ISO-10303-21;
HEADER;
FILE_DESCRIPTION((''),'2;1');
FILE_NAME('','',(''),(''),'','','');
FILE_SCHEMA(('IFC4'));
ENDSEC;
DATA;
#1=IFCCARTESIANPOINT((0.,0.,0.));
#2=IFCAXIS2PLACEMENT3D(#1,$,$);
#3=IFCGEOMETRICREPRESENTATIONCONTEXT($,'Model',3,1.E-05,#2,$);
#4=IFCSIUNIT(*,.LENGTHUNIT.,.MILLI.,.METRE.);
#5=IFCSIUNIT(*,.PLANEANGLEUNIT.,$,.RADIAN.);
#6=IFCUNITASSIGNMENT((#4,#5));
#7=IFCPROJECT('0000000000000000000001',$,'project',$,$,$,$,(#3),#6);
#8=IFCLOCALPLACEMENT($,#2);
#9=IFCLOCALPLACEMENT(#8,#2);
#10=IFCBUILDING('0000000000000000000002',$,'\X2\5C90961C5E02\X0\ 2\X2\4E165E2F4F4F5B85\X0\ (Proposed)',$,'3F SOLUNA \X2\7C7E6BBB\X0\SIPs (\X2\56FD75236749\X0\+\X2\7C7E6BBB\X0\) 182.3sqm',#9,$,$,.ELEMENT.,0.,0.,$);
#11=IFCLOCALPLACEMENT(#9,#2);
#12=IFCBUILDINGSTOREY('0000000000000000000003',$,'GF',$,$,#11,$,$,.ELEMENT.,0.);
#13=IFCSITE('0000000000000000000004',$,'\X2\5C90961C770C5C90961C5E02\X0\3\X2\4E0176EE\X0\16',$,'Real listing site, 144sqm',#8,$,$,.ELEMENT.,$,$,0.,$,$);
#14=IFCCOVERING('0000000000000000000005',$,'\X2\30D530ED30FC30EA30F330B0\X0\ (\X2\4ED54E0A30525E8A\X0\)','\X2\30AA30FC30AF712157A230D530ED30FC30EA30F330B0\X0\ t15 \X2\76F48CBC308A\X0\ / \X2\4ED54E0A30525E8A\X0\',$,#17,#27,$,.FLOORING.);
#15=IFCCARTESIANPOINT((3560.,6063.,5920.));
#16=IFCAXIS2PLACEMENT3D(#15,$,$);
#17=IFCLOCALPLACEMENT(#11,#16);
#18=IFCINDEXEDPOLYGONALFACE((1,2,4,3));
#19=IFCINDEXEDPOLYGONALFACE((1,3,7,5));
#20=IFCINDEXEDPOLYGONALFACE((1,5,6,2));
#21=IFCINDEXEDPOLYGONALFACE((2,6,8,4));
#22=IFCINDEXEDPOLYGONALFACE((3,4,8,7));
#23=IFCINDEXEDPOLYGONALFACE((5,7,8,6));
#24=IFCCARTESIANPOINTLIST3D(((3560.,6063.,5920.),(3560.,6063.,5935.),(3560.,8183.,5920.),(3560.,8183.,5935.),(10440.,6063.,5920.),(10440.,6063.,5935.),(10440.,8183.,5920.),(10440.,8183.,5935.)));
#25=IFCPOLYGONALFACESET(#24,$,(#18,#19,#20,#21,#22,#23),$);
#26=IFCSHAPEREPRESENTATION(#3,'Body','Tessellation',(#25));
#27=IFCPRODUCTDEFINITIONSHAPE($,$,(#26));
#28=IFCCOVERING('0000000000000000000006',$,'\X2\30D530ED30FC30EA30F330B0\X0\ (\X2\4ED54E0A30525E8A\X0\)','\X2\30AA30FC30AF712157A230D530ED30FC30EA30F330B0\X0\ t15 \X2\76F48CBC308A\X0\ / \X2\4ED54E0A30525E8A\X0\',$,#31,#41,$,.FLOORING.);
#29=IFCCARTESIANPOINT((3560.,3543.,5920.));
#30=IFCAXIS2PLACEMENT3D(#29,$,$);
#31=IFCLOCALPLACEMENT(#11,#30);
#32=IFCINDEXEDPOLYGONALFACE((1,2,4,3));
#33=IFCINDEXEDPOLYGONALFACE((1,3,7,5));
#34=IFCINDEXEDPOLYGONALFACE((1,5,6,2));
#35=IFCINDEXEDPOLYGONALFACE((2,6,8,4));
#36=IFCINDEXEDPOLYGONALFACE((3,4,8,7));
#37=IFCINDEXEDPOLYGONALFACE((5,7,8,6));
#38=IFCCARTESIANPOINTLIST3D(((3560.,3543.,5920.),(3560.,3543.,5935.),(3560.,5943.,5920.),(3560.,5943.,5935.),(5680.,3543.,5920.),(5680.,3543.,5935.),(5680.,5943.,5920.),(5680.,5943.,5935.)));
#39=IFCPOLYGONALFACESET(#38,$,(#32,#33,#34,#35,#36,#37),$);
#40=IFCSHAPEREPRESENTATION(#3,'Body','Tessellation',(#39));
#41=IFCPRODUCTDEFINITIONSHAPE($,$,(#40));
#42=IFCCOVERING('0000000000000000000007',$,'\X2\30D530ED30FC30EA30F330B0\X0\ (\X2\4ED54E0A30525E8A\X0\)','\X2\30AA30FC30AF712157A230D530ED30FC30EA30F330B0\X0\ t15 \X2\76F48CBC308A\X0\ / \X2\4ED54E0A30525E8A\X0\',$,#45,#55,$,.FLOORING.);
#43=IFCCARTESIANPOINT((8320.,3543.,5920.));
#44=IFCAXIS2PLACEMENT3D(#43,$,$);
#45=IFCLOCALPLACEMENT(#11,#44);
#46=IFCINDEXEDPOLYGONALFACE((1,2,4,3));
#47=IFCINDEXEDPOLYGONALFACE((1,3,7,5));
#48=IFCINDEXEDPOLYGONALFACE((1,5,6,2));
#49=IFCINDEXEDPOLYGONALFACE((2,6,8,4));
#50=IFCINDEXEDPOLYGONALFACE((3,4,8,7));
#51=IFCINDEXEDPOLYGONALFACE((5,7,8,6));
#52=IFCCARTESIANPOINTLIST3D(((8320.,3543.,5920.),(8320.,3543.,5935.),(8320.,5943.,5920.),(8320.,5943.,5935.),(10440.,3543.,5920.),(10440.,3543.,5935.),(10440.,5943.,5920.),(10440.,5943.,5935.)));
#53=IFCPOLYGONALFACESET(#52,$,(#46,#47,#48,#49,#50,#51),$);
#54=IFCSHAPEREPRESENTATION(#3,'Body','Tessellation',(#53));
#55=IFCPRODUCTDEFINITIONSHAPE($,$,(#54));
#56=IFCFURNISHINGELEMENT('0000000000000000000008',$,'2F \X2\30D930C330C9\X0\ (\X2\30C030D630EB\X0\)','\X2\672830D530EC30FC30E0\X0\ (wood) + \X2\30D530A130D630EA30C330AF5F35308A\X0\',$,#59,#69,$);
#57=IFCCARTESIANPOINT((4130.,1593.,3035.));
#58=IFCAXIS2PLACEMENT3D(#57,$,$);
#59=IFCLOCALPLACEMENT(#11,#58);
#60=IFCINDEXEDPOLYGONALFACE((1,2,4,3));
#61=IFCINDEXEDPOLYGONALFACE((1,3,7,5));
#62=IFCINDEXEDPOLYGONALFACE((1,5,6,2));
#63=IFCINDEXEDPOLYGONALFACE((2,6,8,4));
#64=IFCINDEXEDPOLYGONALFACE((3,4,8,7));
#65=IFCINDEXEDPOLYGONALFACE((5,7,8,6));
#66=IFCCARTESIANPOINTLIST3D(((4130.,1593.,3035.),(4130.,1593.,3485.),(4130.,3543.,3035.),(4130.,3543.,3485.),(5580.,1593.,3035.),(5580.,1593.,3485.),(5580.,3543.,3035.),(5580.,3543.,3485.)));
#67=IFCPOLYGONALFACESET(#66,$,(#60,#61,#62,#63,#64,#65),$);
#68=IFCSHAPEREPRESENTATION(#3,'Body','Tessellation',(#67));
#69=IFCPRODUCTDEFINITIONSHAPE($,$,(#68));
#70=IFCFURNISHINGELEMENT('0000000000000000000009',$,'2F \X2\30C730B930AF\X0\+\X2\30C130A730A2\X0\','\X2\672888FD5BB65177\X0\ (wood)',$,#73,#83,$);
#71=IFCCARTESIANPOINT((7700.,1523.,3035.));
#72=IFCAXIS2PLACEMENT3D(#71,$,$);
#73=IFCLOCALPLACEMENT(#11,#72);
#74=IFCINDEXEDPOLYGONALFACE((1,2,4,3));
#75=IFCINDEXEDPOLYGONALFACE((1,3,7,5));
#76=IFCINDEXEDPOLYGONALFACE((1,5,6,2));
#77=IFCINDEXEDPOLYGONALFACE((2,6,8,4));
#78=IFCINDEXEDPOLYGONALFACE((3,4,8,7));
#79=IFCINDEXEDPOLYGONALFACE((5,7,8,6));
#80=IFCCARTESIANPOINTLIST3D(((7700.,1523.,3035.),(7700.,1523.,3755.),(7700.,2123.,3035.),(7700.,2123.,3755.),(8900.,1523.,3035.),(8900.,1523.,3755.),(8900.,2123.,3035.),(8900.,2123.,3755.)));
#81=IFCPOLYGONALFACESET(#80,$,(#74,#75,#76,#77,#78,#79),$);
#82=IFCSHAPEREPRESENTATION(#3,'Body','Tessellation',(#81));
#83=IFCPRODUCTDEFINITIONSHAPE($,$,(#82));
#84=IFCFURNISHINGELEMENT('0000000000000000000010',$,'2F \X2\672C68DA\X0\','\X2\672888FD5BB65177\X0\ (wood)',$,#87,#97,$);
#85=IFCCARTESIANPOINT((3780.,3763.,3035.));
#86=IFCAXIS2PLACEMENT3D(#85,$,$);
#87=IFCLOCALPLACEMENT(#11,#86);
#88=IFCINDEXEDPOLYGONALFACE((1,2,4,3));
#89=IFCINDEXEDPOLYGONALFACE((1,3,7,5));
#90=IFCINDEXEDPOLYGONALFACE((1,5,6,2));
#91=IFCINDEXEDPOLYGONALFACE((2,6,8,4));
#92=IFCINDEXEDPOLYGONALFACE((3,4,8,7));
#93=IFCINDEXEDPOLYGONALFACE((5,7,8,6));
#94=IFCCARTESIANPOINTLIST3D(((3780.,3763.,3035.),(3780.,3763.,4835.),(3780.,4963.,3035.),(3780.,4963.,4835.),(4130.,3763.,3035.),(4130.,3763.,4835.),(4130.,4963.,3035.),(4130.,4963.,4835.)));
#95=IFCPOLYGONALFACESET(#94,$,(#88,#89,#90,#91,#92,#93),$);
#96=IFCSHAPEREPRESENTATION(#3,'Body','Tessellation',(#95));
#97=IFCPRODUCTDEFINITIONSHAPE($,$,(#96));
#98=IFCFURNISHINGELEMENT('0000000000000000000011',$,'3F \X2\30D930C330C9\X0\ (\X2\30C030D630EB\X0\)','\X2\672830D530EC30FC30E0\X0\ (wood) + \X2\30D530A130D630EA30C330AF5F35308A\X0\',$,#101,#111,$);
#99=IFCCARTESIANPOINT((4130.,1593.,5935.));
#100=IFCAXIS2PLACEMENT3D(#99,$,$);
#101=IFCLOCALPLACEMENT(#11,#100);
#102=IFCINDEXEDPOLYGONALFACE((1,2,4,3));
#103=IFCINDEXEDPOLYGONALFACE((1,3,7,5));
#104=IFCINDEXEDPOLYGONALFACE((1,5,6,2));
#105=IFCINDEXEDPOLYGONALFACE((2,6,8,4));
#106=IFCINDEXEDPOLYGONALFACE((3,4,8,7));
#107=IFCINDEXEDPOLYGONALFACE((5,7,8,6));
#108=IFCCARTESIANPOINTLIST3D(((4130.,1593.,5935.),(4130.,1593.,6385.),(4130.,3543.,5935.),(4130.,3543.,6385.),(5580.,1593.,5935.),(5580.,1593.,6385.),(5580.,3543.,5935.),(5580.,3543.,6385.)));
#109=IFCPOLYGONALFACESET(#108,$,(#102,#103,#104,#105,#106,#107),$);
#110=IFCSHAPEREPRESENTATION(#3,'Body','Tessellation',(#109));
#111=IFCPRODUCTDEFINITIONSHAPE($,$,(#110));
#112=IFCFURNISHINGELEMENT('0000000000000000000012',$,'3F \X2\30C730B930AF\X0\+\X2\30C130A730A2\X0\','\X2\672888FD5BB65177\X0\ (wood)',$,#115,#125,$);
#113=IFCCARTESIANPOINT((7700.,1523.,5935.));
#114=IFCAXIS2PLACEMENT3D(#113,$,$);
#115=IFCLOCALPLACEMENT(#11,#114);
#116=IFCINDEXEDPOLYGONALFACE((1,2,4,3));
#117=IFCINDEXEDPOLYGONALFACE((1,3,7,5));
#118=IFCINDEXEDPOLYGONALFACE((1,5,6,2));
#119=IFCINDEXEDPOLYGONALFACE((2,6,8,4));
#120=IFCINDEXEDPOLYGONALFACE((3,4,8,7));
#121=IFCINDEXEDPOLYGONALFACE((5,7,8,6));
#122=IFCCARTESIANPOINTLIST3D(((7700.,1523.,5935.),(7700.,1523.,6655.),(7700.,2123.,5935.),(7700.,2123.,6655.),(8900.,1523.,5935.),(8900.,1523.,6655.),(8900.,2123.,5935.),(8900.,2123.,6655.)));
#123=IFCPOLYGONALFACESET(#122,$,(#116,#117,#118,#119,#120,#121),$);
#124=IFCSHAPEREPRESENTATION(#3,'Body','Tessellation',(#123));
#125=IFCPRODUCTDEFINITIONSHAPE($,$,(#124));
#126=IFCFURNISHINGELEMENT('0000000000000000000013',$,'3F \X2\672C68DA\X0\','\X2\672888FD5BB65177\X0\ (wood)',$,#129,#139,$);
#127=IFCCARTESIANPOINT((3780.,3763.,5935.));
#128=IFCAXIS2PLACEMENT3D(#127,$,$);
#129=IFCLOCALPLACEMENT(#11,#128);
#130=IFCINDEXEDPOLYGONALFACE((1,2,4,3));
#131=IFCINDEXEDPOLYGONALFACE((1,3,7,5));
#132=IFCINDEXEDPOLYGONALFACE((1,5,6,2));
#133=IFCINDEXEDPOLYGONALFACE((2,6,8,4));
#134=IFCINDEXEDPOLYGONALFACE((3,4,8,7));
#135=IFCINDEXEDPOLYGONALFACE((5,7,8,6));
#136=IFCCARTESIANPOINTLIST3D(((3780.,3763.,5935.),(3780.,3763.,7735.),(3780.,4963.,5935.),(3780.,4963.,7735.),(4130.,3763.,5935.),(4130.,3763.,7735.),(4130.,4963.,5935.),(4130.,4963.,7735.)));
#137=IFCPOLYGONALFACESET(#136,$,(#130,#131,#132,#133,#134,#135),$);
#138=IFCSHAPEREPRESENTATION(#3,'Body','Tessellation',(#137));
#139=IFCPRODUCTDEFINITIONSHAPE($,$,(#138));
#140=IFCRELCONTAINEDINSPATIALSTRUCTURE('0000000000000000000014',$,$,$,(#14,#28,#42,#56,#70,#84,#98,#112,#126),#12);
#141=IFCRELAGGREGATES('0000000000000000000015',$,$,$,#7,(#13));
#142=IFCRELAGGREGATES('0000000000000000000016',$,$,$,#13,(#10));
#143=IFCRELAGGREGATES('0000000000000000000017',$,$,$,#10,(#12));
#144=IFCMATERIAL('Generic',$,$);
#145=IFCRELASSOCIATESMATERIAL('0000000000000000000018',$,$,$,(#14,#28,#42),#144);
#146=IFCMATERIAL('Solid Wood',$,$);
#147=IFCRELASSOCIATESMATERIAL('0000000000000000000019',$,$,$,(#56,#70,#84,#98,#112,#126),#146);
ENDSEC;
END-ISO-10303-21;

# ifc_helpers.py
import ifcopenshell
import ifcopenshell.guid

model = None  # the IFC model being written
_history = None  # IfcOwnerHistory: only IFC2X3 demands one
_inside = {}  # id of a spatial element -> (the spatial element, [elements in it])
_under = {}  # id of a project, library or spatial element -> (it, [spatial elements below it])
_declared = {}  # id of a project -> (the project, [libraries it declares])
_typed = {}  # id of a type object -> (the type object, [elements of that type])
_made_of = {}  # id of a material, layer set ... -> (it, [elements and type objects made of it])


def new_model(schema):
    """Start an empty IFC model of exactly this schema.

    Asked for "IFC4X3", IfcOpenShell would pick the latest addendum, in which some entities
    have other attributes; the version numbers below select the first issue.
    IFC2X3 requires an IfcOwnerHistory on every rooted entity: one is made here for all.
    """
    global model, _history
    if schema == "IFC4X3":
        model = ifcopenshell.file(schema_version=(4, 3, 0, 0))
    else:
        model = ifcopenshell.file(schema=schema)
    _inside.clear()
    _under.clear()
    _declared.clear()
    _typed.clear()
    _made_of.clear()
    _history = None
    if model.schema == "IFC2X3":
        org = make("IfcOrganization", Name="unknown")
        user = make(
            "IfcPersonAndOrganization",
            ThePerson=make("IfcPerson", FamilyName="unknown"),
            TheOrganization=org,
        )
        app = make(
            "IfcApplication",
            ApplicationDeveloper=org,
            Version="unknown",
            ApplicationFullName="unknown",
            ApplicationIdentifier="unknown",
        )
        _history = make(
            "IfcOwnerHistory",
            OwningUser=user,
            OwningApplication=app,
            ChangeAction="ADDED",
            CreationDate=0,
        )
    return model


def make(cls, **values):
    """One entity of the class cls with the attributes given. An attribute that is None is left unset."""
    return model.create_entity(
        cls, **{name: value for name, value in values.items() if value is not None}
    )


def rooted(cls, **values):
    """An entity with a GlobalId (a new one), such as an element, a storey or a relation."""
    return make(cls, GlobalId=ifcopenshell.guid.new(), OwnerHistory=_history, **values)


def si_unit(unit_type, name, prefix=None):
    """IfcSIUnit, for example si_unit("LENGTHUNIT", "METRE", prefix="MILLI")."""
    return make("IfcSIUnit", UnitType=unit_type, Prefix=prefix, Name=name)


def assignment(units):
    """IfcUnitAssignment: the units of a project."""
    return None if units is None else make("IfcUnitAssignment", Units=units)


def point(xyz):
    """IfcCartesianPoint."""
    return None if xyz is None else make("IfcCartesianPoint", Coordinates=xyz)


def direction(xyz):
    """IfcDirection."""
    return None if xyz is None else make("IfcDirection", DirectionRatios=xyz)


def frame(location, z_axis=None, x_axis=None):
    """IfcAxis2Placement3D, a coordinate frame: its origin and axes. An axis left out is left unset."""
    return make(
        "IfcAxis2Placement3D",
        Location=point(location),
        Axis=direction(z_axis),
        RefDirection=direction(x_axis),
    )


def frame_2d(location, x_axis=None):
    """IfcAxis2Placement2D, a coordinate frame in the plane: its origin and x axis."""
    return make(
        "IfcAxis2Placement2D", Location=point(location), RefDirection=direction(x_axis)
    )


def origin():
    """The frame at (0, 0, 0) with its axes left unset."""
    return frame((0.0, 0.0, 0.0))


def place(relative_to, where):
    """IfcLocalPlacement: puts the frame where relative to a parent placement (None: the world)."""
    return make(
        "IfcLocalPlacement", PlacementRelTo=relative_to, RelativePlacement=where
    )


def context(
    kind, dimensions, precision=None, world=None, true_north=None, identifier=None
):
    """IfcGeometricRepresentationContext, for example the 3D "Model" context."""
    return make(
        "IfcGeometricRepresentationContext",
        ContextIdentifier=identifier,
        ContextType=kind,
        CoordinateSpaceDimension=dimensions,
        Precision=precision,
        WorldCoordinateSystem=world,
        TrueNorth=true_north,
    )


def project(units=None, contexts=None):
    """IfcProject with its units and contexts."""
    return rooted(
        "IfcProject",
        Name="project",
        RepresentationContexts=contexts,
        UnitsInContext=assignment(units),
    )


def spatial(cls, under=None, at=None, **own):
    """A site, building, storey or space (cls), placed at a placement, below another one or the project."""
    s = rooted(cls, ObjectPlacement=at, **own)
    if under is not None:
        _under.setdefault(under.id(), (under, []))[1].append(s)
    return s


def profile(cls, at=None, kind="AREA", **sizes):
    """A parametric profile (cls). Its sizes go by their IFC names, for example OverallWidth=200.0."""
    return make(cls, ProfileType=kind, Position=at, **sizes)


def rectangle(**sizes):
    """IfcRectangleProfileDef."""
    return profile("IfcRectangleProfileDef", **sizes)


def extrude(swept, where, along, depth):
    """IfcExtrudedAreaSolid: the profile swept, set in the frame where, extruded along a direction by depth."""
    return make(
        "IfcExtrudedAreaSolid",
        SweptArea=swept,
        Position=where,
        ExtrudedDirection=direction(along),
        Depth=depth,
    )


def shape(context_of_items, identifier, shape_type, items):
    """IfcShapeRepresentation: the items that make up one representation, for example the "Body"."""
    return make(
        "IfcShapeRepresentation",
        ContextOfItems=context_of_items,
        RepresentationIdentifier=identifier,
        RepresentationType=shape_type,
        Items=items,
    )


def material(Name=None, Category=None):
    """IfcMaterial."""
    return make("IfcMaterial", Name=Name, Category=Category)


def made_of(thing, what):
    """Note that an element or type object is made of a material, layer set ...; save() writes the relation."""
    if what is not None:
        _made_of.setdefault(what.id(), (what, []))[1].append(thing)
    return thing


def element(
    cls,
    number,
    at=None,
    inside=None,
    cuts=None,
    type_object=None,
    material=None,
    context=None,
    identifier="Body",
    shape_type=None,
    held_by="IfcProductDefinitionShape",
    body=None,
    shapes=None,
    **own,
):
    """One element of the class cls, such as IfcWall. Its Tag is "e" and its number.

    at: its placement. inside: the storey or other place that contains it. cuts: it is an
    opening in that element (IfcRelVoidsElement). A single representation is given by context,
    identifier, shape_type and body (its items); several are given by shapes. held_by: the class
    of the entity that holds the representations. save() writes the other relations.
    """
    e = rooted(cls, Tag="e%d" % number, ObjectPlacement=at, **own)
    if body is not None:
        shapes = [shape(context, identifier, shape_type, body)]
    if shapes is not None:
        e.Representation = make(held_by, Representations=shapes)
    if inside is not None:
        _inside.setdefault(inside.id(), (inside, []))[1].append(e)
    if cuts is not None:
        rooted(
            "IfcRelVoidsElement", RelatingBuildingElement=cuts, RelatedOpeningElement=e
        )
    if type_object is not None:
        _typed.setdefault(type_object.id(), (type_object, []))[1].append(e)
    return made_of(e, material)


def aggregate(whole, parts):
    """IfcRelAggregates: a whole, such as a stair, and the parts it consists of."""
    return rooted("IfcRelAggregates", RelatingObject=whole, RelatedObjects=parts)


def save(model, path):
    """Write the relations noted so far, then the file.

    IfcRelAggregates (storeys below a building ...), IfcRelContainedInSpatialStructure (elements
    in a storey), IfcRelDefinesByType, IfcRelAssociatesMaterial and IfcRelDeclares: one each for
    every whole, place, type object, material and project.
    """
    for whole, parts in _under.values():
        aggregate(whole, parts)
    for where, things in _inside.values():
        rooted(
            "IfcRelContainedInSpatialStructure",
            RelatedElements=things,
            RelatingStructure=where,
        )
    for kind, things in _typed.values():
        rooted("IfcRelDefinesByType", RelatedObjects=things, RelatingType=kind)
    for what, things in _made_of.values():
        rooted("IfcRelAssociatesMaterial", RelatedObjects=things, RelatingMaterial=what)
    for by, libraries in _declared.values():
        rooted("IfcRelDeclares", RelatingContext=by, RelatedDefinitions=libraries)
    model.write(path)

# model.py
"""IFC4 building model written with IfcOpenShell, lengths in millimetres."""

from ifc_helpers import new_model, si_unit, frame, frame_2d, origin, place, context, project, spatial, rectangle, extrude, material, element, save


model = new_model("IFC4")

# Units and contexts
model_context = context("Model", 3, precision=1e-05, world=origin())
ifc_project = project(units=[si_unit("LENGTHUNIT", "METRE", prefix="MILLI"), si_unit("PLANEANGLEUNIT", "RADIAN")], contexts=[model_context])

# Site, building, storey
site_placement = place(None, origin())
site = spatial("IfcSite", under=ifc_project, at=site_placement, Name="岐阜県岐阜市3丁目16", ObjectType="Real listing site, 144sqm", CompositionType="ELEMENT", RefElevation=0.0)
building_placement = place(site_placement, origin())
building = spatial("IfcBuilding", under=site, at=building_placement, Name="岐阜市 2世帯住宅 (Proposed)", ObjectType="3F SOLUNA 籾殻SIPs (国産杉+籾殻) 182.3sqm", CompositionType="ELEMENT", ElevationOfRefHeight=0.0, ElevationOfTerrain=0.0)
storey_placement = place(building_placement, origin())
storey = spatial("IfcBuildingStorey", under=building, at=storey_placement, Name="GF", CompositionType="ELEMENT", Elevation=0.0)

# Shared definitions
ifc_material_1 = material(Name="Solid Wood")

# Shared definitions
ifc_material_2 = material(Name="Generic")

# Coverings
covering_1_placement = place(storey_placement, frame((3560.0, 6063.0, 5920.0)))
element("IfcCovering", 1, at=covering_1_placement, inside=storey, material=ifc_material_2, Name="フローリング (仕上げ床)", Description="オーク無垢フローリング t15 直貼り / 仕上げ床", PredefinedType="FLOORING", context=model_context, shape_type="SweptSolid", body=[
    extrude(rectangle(XDim=6880.0, YDim=2120.0, at=frame_2d((3440.0, 1060.0))), frame((3560.0, 6063.0, 5920.0)), (0.0, 0.0, 1.0), 15.0),
])
covering_2_placement = place(storey_placement, frame((3560.0, 3543.0, 5920.0)))
element("IfcCovering", 2, at=covering_2_placement, inside=storey, material=ifc_material_2, Name="フローリング (仕上げ床)", Description="オーク無垢フローリング t15 直貼り / 仕上げ床", PredefinedType="FLOORING", context=model_context, shape_type="SweptSolid", body=[
    extrude(rectangle(XDim=2120.0, YDim=2400.0, at=frame_2d((1060.0, 1200.0))), frame((3560.0, 3543.0, 5920.0)), (0.0, 0.0, 1.0), 15.0),
])
covering_3_placement = place(storey_placement, frame((8320.0, 3543.0, 5920.0)))
element("IfcCovering", 3, at=covering_3_placement, inside=storey, material=ifc_material_2, Name="フローリング (仕上げ床)", Description="オーク無垢フローリング t15 直貼り / 仕上げ床", PredefinedType="FLOORING", context=model_context, shape_type="SweptSolid", body=[
    extrude(rectangle(XDim=2120.0, YDim=2400.0, at=frame_2d((1060.0, 1200.0))), frame((8320.0, 3543.0, 5920.0)), (0.0, 0.0, 1.0), 15.0),
])

# Furnishing elements
furnishing_1_placement = place(storey_placement, frame((4130.0, 1593.0, 3035.0)))
element("IfcFurnishingElement", 4, at=furnishing_1_placement, inside=storey, material=ifc_material_1, Name="2F ベッド (ダブル)", Description="木フレーム (wood) + ファブリック張り", context=model_context, shape_type="SweptSolid", body=[
    extrude(rectangle(XDim=1450.0, YDim=1950.0, at=frame_2d((725.0, 975.0))), frame((4130.0, 1593.0, 3035.0)), (0.0, 0.0, 1.0), 450.0),
])
furnishing_2_placement = place(storey_placement, frame((7700.0, 1523.0, 3035.0)))
element("IfcFurnishingElement", 5, at=furnishing_2_placement, inside=storey, material=ifc_material_1, Name="2F デスク+チェア", Description="木製家具 (wood)", context=model_context, shape_type="SweptSolid", body=[
    extrude(rectangle(XDim=1200.0, YDim=600.0, at=frame_2d((600.0, 300.0))), frame((7700.0, 1523.0, 3035.0)), (0.0, 0.0, 1.0), 720.0),
])
furnishing_3_placement = place(storey_placement, frame((3780.0, 3763.0, 3035.0)))
element("IfcFurnishingElement", 6, at=furnishing_3_placement, inside=storey, material=ifc_material_1, Name="2F 本棚", Description="木製家具 (wood)", context=model_context, shape_type="SweptSolid", body=[
    extrude(rectangle(XDim=350.0, YDim=1200.0, at=frame_2d((175.0, 600.0))), frame((3780.0, 3763.0, 3035.0)), (0.0, 0.0, 1.0), 1800.0),
])
furnishing_4_placement = place(storey_placement, frame((4130.0, 1593.0, 5935.0)))
element("IfcFurnishingElement", 7, at=furnishing_4_placement, inside=storey, material=ifc_material_1, Name="3F ベッド (ダブル)", Description="木フレーム (wood) + ファブリック張り", context=model_context, shape_type="SweptSolid", body=[
    extrude(rectangle(XDim=1450.0, YDim=1950.0, at=frame_2d((725.0, 975.0))), frame((4130.0, 1593.0, 5935.0)), (0.0, 0.0, 1.0), 450.0),
])
furnishing_5_placement = place(storey_placement, frame((7700.0, 1523.0, 5935.0)))
element("IfcFurnishingElement", 8, at=furnishing_5_placement, inside=storey, material=ifc_material_1, Name="3F デスク+チェア", Description="木製家具 (wood)", context=model_context, shape_type="SweptSolid", body=[
    extrude(rectangle(XDim=1200.0, YDim=600.0, at=frame_2d((600.0, 300.0))), frame((7700.0, 1523.0, 5935.0)), (0.0, 0.0, 1.0), 720.0),
])
furnishing_6_placement = place(storey_placement, frame((3780.0, 3763.0, 5935.0)))
element("IfcFurnishingElement", 9, at=furnishing_6_placement, inside=storey, material=ifc_material_1, Name="3F 本棚", Description="木製家具 (wood)", context=model_context, shape_type="SweptSolid", body=[
    extrude(rectangle(XDim=350.0, YDim=1200.0, at=frame_2d((175.0, 600.0))), frame((3780.0, 3763.0, 5935.0)), (0.0, 0.0, 1.0), 1800.0),
])

save(model, "model.ifc")
